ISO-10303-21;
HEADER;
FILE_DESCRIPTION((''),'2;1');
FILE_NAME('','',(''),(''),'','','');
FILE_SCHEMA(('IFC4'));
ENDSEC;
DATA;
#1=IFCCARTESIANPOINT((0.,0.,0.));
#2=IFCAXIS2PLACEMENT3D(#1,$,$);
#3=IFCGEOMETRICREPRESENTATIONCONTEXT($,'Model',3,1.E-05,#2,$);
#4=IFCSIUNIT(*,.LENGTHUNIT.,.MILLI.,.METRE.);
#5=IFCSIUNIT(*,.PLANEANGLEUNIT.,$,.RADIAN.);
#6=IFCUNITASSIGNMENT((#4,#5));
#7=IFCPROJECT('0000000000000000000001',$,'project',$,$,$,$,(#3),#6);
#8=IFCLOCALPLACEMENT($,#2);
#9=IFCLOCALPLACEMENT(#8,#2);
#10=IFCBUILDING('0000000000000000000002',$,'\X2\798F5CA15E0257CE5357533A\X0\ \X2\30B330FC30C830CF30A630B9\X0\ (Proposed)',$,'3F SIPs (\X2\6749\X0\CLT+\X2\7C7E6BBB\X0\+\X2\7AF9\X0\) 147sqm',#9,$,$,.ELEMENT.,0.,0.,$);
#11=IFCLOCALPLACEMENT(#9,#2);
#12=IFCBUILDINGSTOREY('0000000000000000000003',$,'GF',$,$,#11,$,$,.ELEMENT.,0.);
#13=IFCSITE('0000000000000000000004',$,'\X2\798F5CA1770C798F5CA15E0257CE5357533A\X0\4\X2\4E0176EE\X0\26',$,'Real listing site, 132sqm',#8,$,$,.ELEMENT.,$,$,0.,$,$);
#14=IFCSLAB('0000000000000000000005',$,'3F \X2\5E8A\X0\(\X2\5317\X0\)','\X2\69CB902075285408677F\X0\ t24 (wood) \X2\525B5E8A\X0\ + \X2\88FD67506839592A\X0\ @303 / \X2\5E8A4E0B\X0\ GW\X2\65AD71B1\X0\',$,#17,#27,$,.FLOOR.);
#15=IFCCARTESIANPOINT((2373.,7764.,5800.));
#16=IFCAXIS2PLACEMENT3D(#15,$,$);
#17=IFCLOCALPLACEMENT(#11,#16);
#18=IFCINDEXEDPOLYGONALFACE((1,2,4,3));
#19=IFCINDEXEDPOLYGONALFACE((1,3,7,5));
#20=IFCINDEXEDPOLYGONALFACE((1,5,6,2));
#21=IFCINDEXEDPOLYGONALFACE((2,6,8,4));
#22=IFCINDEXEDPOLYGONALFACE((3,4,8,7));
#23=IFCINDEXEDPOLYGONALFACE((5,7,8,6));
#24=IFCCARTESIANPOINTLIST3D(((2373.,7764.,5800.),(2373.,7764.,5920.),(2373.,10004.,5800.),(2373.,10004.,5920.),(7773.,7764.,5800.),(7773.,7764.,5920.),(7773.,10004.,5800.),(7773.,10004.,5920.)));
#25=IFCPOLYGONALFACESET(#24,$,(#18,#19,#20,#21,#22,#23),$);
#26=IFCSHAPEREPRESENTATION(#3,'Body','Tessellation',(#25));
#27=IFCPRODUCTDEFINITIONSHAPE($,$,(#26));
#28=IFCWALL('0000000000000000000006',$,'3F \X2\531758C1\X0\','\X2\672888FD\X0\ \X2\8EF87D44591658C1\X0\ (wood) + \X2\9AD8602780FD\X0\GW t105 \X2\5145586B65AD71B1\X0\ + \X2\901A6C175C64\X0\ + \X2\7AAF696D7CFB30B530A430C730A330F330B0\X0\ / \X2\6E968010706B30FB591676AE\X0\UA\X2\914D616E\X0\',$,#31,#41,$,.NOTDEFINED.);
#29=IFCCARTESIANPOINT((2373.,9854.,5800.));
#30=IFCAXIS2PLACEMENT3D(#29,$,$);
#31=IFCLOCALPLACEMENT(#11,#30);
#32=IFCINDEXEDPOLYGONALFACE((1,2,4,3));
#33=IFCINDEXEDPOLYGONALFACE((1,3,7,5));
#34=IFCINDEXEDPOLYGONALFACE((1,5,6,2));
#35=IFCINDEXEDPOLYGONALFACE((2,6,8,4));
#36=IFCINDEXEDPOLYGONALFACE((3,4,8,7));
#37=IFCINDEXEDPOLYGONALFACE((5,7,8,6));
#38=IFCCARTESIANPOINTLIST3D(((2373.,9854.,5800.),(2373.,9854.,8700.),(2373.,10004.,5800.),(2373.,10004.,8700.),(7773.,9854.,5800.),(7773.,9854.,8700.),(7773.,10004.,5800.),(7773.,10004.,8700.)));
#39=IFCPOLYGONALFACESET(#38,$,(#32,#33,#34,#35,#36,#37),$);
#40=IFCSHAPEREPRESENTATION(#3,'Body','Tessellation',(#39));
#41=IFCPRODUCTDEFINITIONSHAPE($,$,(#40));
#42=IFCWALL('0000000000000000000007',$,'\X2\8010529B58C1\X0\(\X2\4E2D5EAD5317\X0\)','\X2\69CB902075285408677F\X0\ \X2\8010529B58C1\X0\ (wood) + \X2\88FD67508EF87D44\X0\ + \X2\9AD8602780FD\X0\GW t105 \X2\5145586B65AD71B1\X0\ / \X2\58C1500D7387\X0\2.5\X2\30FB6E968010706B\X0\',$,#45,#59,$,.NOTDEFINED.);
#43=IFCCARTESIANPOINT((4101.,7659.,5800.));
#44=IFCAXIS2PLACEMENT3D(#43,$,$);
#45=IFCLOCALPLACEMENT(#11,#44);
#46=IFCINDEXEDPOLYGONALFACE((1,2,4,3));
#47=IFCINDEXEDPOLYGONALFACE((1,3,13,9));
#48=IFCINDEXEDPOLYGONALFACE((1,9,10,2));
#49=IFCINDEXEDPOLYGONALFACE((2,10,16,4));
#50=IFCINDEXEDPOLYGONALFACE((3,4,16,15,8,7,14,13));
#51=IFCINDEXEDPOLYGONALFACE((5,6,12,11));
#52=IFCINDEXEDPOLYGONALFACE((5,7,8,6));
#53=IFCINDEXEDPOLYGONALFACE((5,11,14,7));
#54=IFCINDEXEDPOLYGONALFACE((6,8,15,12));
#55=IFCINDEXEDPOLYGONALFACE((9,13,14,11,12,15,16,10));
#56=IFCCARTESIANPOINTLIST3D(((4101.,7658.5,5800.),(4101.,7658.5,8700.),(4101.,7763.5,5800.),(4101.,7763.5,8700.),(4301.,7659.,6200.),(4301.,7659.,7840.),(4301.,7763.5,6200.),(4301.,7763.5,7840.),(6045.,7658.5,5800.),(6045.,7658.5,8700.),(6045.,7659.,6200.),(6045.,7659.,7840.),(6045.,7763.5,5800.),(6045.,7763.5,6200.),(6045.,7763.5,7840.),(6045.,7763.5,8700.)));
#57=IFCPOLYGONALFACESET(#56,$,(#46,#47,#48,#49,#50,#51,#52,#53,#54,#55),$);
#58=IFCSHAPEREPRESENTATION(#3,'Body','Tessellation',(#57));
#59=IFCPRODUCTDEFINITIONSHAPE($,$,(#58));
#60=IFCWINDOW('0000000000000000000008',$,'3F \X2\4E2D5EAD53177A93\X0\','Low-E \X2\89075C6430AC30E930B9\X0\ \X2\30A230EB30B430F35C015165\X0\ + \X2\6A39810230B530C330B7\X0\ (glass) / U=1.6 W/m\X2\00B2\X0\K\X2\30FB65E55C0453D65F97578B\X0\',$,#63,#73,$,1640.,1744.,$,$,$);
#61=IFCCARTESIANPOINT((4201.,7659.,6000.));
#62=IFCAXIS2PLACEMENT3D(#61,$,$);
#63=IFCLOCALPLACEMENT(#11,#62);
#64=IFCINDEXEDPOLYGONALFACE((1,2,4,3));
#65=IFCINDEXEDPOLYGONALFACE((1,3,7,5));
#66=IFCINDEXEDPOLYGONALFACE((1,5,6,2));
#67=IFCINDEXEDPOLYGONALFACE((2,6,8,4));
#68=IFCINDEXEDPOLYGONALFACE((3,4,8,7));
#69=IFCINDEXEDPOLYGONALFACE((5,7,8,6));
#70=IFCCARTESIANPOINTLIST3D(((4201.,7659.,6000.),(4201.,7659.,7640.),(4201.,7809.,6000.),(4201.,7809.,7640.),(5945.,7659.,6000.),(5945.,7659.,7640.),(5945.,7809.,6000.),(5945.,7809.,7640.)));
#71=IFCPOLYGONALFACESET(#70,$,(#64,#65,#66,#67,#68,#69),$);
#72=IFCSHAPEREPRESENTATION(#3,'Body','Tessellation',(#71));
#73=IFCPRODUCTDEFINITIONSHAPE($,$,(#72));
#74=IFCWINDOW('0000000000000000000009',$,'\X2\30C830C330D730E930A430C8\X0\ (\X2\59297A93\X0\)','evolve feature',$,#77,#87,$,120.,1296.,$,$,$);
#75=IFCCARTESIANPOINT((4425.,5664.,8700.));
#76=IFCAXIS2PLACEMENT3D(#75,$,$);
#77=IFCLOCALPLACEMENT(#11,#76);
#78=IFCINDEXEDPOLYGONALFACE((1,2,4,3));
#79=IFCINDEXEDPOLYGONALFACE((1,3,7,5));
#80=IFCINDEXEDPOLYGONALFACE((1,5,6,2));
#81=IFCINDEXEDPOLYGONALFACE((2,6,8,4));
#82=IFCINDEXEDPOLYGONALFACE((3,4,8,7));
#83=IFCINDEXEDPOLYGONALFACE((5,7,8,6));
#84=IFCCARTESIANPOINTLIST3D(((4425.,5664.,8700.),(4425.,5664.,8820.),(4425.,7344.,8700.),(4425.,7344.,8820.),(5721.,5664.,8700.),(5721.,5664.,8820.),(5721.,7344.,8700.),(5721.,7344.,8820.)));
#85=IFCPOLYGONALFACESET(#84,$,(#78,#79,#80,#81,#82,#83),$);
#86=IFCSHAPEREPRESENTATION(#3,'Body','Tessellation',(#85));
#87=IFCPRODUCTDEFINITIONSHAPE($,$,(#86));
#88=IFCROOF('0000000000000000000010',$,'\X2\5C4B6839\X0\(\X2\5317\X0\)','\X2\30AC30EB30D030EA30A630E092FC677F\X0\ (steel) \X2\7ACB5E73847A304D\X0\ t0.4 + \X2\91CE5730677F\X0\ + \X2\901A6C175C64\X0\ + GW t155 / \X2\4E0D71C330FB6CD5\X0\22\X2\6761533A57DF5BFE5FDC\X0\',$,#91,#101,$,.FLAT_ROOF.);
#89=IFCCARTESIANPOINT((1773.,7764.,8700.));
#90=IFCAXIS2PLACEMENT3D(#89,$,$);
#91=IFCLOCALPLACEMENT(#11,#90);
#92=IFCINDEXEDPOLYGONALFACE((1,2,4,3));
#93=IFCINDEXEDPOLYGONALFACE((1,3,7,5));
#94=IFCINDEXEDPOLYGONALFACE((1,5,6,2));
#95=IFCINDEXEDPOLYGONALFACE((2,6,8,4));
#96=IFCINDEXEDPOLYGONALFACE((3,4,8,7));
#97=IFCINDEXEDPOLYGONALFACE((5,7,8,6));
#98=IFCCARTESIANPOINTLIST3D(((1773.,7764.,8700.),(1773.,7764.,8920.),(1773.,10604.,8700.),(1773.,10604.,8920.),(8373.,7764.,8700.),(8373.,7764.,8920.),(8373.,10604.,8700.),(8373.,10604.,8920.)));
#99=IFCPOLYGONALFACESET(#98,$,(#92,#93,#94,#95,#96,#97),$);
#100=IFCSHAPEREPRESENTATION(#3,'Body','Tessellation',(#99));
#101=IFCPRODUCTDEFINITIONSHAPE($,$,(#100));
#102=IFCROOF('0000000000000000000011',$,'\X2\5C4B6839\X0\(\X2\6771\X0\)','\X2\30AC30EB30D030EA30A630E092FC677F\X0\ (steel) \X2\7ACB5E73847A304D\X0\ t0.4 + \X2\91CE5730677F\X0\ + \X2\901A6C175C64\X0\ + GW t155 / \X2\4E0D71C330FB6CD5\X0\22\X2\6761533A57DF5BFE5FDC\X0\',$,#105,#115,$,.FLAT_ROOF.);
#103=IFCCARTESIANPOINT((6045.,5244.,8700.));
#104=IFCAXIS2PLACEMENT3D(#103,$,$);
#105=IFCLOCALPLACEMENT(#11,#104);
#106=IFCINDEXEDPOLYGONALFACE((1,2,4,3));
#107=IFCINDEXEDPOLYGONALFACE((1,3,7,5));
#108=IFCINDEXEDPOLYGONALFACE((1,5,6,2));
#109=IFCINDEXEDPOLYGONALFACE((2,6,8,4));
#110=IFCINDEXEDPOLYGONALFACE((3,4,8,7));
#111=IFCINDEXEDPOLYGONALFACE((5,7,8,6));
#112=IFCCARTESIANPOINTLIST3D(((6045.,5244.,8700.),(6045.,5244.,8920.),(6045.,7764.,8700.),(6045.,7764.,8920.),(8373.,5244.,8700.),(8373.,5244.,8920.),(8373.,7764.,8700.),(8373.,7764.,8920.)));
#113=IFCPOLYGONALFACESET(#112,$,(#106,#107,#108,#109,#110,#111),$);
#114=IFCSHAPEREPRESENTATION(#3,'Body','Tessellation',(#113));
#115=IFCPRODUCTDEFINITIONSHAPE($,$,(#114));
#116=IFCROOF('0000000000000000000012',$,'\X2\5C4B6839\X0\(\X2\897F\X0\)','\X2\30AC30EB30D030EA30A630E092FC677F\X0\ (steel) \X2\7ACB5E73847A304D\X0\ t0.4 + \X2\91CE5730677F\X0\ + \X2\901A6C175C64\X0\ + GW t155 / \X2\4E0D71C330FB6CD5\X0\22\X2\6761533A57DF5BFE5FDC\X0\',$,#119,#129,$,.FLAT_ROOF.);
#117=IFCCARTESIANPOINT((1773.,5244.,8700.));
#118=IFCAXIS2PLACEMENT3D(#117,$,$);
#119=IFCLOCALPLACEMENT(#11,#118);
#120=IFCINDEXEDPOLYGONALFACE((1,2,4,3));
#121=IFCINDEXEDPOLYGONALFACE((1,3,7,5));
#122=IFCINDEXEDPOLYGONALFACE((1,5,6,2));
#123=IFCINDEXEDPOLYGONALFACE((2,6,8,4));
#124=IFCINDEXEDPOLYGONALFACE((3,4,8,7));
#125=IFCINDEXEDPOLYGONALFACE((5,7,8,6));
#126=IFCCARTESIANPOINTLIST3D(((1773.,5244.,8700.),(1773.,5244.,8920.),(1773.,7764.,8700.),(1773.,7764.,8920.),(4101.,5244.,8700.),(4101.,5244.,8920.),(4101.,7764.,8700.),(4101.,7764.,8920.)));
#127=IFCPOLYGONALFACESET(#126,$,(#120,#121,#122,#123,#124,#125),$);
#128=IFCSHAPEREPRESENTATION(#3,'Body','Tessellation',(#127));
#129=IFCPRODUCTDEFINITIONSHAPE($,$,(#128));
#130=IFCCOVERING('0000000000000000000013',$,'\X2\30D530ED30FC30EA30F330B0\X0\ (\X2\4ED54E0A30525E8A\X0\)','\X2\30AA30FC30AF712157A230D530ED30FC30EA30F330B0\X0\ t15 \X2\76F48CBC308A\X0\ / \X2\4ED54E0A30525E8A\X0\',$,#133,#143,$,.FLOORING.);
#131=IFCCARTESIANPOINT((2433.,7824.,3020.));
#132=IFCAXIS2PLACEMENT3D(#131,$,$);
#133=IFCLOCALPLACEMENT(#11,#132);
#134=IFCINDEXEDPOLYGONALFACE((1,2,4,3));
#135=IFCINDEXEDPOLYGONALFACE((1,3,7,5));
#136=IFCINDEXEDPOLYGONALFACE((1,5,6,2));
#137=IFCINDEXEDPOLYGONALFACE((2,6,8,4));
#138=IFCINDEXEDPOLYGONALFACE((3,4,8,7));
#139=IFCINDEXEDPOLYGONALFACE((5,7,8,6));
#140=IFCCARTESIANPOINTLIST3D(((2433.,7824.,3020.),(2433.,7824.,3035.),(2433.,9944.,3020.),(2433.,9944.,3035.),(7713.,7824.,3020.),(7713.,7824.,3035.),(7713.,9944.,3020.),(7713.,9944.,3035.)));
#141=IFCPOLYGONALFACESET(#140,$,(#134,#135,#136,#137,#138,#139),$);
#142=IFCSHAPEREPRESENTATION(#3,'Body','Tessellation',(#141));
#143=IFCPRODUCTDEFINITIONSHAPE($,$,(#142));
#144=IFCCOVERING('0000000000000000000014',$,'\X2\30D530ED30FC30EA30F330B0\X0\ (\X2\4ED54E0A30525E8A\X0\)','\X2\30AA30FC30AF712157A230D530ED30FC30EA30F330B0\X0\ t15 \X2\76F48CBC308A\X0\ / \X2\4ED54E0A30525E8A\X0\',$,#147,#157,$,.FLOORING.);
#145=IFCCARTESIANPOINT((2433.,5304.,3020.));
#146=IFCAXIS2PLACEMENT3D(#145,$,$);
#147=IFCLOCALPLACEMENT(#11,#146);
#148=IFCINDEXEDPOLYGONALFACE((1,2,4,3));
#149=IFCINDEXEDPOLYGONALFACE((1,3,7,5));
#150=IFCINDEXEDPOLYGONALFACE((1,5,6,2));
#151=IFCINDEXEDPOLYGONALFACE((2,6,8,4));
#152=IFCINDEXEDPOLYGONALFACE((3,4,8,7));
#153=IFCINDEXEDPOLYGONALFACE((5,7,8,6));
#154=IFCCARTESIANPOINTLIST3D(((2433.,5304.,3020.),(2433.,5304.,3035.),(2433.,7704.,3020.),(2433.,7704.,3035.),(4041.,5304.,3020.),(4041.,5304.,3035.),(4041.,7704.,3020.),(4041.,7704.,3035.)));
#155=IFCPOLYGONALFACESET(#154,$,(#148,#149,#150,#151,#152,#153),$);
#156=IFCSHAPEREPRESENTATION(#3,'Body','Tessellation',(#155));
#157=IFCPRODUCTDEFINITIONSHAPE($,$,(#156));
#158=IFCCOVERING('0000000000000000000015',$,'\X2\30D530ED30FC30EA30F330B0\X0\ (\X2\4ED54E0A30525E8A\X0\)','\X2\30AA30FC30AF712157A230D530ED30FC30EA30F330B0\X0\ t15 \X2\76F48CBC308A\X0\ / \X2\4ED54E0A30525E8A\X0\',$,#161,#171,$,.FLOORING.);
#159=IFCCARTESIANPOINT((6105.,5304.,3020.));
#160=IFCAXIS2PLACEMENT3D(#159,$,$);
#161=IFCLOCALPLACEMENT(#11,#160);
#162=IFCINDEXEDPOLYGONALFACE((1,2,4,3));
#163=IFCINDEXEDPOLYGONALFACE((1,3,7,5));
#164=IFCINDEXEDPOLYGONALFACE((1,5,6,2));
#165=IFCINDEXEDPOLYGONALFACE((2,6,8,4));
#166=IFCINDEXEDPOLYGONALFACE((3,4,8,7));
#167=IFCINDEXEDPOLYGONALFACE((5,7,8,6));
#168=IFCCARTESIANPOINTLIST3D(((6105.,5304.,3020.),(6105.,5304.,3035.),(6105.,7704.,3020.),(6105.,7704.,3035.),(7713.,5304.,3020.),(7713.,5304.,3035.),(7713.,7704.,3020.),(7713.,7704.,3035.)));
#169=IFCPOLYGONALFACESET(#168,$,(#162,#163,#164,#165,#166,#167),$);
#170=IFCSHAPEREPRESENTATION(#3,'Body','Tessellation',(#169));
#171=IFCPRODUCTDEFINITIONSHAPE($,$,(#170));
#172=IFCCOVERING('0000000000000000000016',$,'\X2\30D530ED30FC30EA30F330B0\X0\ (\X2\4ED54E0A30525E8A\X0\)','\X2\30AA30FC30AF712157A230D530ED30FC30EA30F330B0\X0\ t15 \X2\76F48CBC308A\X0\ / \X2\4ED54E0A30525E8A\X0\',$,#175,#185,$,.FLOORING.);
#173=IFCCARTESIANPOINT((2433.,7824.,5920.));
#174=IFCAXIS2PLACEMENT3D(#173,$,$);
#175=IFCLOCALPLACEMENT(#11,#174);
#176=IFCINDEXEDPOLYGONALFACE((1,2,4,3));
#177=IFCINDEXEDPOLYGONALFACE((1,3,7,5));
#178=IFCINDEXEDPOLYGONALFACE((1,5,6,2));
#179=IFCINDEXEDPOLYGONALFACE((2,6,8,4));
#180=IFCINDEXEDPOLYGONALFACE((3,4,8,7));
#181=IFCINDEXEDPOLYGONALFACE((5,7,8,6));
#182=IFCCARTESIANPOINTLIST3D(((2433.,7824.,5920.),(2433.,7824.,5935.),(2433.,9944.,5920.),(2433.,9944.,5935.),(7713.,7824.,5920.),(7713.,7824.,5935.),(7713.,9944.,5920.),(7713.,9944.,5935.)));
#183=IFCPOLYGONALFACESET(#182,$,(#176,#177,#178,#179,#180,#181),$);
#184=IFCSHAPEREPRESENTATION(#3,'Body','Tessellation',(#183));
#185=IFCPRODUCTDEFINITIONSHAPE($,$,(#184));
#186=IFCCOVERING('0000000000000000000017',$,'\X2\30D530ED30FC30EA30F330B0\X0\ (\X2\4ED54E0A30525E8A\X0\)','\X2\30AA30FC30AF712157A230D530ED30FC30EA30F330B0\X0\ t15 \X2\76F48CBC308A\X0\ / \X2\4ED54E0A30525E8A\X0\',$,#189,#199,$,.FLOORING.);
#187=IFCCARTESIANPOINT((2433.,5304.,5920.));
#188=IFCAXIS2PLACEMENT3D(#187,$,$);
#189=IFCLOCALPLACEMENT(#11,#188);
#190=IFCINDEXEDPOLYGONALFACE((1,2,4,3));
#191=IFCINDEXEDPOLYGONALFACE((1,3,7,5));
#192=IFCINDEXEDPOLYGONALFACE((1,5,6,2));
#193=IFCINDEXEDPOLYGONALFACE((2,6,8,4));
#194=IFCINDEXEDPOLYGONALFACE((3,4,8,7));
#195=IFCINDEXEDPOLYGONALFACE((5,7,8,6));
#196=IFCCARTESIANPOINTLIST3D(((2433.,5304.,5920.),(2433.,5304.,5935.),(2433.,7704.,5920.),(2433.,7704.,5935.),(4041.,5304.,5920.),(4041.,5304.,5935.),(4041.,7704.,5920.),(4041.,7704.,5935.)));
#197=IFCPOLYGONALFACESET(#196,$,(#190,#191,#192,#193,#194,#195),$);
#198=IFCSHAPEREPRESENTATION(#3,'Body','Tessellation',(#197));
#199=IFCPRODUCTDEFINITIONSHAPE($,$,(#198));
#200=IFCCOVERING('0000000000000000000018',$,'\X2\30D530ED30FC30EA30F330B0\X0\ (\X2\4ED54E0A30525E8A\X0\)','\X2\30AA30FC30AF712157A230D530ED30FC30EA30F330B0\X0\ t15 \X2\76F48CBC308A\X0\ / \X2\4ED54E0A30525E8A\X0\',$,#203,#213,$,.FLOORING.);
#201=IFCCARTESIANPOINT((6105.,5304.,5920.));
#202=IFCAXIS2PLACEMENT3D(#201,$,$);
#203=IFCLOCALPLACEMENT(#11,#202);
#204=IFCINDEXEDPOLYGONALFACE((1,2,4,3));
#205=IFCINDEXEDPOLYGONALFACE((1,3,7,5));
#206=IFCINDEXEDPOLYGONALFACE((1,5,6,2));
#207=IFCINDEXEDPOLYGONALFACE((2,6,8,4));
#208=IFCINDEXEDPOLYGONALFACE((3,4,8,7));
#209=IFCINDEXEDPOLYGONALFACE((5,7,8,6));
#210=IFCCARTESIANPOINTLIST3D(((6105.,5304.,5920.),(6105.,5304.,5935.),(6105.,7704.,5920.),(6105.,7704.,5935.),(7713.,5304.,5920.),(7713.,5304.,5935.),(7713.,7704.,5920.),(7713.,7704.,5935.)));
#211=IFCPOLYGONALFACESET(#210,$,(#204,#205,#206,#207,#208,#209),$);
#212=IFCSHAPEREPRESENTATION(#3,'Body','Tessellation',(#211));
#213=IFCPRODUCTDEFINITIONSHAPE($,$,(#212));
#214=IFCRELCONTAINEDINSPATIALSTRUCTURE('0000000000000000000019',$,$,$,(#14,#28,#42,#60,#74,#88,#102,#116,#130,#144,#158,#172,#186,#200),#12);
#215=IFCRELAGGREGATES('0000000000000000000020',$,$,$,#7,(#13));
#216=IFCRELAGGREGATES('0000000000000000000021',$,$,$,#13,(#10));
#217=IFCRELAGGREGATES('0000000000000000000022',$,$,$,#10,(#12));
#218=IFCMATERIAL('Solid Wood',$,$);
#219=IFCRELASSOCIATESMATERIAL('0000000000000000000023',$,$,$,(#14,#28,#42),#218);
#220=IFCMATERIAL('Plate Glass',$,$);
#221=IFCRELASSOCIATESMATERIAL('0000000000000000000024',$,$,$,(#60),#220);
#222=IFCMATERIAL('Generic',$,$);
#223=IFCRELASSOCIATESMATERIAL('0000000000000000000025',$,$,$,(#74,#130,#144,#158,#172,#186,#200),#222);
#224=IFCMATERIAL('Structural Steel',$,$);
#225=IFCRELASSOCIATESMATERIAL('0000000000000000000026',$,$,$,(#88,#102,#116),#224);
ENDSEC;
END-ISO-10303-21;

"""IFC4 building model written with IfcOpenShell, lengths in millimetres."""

from ifc_helpers import new_model, si_unit, frame, frame_2d, origin, place, context, project, spatial, rectangle, extrude, material, element, fill, save


model = new_model("IFC4")

# Units and contexts
model_context = context("Model", 3, precision=1e-05, world=origin())
ifc_project = project(units=[si_unit("LENGTHUNIT", "METRE", prefix="MILLI"), si_unit("PLANEANGLEUNIT", "RADIAN")], contexts=[model_context])

# Site, building, storey
site_placement = place(None, origin())
site = spatial("IfcSite", under=ifc_project, at=site_placement, Name="福岡県福岡市城南区4丁目26", ObjectType="Real listing site, 132sqm", CompositionType="ELEMENT", RefElevation=0.0)
building_placement = place(site_placement, origin())
building = spatial("IfcBuilding", under=site, at=building_placement, Name="福岡市城南区 コートハウス (Proposed)", ObjectType="3F SIPs (杉CLT+籾殻+竹) 147sqm", CompositionType="ELEMENT", ElevationOfRefHeight=0.0, ElevationOfTerrain=0.0)
storey_placement = place(building_placement, origin())
storey = spatial("IfcBuildingStorey", under=building, at=storey_placement, Name="GF", CompositionType="ELEMENT", Elevation=0.0)

# Slab
ifc_material_1 = material(Name="Solid Wood")
slab_placement = place(storey_placement, frame((2373.0, 7764.0, 5800.0)))
element("IfcSlab", 1, at=slab_placement, inside=storey, material=ifc_material_1, Name="3F 床(北)", Description="構造用合板 t24 (wood) 剛床 + 製材根太 @303 / 床下 GW断熱", PredefinedType="FLOOR", context=model_context, shape_type="SweptSolid", body=[
    extrude(rectangle(XDim=5400.0, YDim=2240.0, at=frame_2d((2700.0, 1120.0))), frame((2373.0, 7764.0, 5800.0)), (0.0, 0.0, 1.0), 120.0),
])

# Wall
wall_1_placement = place(storey_placement, frame((2373.0, 9854.0, 5800.0)))
element("IfcWall", 2, at=wall_1_placement, inside=storey, material=ifc_material_1, Name="3F 北壁", Description="木製 軸組外壁 (wood) + 高性能GW t105 充填断熱 + 通気層 + 窯業系サイディング / 準耐火・外皮UA配慮", PredefinedType="NOTDEFINED", context=model_context, shape_type="SweptSolid", body=[
    extrude(rectangle(XDim=5400.0, YDim=150.0, at=frame_2d((2700.0, 75.0))), frame((2373.0, 9854.0, 5800.0)), (0.0, 0.0, 1.0), 2900.0),
])

# Wall, opening, window
wall_2_placement = place(storey_placement, frame((4101.0, 7659.0, 5800.0)))
wall_2 = element("IfcWall", 3, at=wall_2_placement, inside=storey, material=ifc_material_1, Name="耐力壁(中庭北)", Description="構造用合板 耐力壁 (wood) + 製材軸組 + 高性能GW t105 充填断熱 / 壁倍率2.5・準耐火", PredefinedType="NOTDEFINED", context=model_context, shape_type="SweptSolid", body=[
    extrude(rectangle(XDim=1944.0, YDim=105.0, at=frame_2d((972.0, 52.0))), frame((4101.0, 7659.0, 5800.0)), (0.0, 0.0, 1.0), 2900.0),
])
opening_placement = place(storey_placement, frame((4201.0, 7659.0, 6000.0)))
opening = element("IfcOpeningElement", 4, at=opening_placement, cuts=wall_2, PredefinedType="NOTDEFINED", context=model_context, shape_type="SweptSolid", body=[
    extrude(rectangle(XDim=1744.0, YDim=150.0, at=frame_2d((872.0, 75.0))), frame((4201.0, 7659.0, 6000.0)), (0.0, 0.0, 1.0), 1640.0),
])
ifc_material_2 = material(Name="Plate Glass")
window_1_placement = place(storey_placement, frame((4201.0, 7659.0, 6000.0)))
window_1 = element("IfcWindow", 5, at=window_1_placement, inside=storey, material=ifc_material_2, Name="3F 中庭北窓", Description="Low-E 複層ガラス アルゴン封入 + 樹脂サッシ (glass) / U=1.6 W/m²K・日射取得型", OverallHeight=1640.0, OverallWidth=1744.0, context=model_context, shape_type="SweptSolid", body=[
    extrude(rectangle(XDim=1744.0, YDim=150.0, at=frame_2d((872.0, 75.0))), frame((4201.0, 7659.0, 6000.0)), (0.0, 0.0, 1.0), 1640.0),
])
fill(opening, window_1)

# Window
ifc_material_3 = material(Name="Generic")
window_2_placement = place(storey_placement, frame((4425.0, 5664.0, 8700.0)))
element("IfcWindow", 6, at=window_2_placement, inside=storey, material=ifc_material_3, Name="トップライト (天窓)", Description="evolve feature", OverallHeight=120.0, OverallWidth=1296.0, context=model_context, shape_type="SweptSolid", body=[
    extrude(rectangle(XDim=1296.0, YDim=1680.0, at=frame_2d((648.0, 840.0))), frame((4425.0, 5664.0, 8700.0)), (0.0, 0.0, 1.0), 120.0),
])

# Roofs
ifc_material_4 = material(Name="Structural Steel")
roof_1_placement = place(storey_placement, frame((1773.0, 7764.0, 8700.0)))
element("IfcRoof", 7, at=roof_1_placement, inside=storey, material=ifc_material_4, Name="屋根(北)", Description="ガルバリウム鋼板 (steel) 立平葺き t0.4 + 野地板 + 通気層 + GW t155 / 不燃・法22条区域対応", PredefinedType="FLAT_ROOF", context=model_context, shape_type="SweptSolid", body=[
    extrude(rectangle(XDim=6600.0, YDim=2840.0, at=frame_2d((3300.0, 1420.0))), frame((1773.0, 7764.0, 8700.0)), (0.0, 0.0, 1.0), 220.0),
])
roof_2_placement = place(storey_placement, frame((6045.0, 5244.0, 8700.0)))
element("IfcRoof", 8, at=roof_2_placement, inside=storey, material=ifc_material_4, Name="屋根(東)", Description="ガルバリウム鋼板 (steel) 立平葺き t0.4 + 野地板 + 通気層 + GW t155 / 不燃・法22条区域対応", PredefinedType="FLAT_ROOF", context=model_context, shape_type="SweptSolid", body=[
    extrude(rectangle(XDim=2328.0, YDim=2520.0, at=frame_2d((1164.0, 1260.0))), frame((6045.0, 5244.0, 8700.0)), (0.0, 0.0, 1.0), 220.0),
])
roof_3_placement = place(storey_placement, frame((1773.0, 5244.0, 8700.0)))
element("IfcRoof", 9, at=roof_3_placement, inside=storey, material=ifc_material_4, Name="屋根(西)", Description="ガルバリウム鋼板 (steel) 立平葺き t0.4 + 野地板 + 通気層 + GW t155 / 不燃・法22条区域対応", PredefinedType="FLAT_ROOF", context=model_context, shape_type="SweptSolid", body=[
    extrude(rectangle(XDim=2328.0, YDim=2520.0, at=frame_2d((1164.0, 1260.0))), frame((1773.0, 5244.0, 8700.0)), (0.0, 0.0, 1.0), 220.0),
])

# Coverings
covering_1_placement = place(storey_placement, frame((2433.0, 7824.0, 3020.0)))
element("IfcCovering", 10, at=covering_1_placement, inside=storey, material=ifc_material_3, Name="フローリング (仕上げ床)", Description="オーク無垢フローリング t15 直貼り / 仕上げ床", PredefinedType="FLOORING", context=model_context, shape_type="SweptSolid", body=[
    extrude(rectangle(XDim=5280.0, YDim=2120.0, at=frame_2d((2640.0, 1060.0))), frame((2433.0, 7824.0, 3020.0)), (0.0, 0.0, 1.0), 15.0),
])
covering_2_placement = place(storey_placement, frame((2433.0, 5304.0, 3020.0)))
element("IfcCovering", 11, at=covering_2_placement, inside=storey, material=ifc_material_3, Name="フローリング (仕上げ床)", Description="オーク無垢フローリング t15 直貼り / 仕上げ床", PredefinedType="FLOORING", context=model_context, shape_type="SweptSolid", body=[
    extrude(rectangle(XDim=1608.0, YDim=2400.0, at=frame_2d((804.0, 1200.0))), frame((2433.0, 5304.0, 3020.0)), (0.0, 0.0, 1.0), 15.0),
])
covering_3_placement = place(storey_placement, frame((6105.0, 5304.0, 3020.0)))
element("IfcCovering", 12, at=covering_3_placement, inside=storey, material=ifc_material_3, Name="フローリング (仕上げ床)", Description="オーク無垢フローリング t15 直貼り / 仕上げ床", PredefinedType="FLOORING", context=model_context, shape_type="SweptSolid", body=[
    extrude(rectangle(XDim=1608.0, YDim=2400.0, at=frame_2d((804.0, 1200.0))), frame((6105.0, 5304.0, 3020.0)), (0.0, 0.0, 1.0), 15.0),
])
covering_4_placement = place(storey_placement, frame((2433.0, 7824.0, 5920.0)))
element("IfcCovering", 13, at=covering_4_placement, inside=storey, material=ifc_material_3, Name="フローリング (仕上げ床)", Description="オーク無垢フローリング t15 直貼り / 仕上げ床", PredefinedType="FLOORING", context=model_context, shape_type="SweptSolid", body=[
    extrude(rectangle(XDim=5280.0, YDim=2120.0, at=frame_2d((2640.0, 1060.0))), frame((2433.0, 7824.0, 5920.0)), (0.0, 0.0, 1.0), 15.0),
])
covering_5_placement = place(storey_placement, frame((2433.0, 5304.0, 5920.0)))
element("IfcCovering", 14, at=covering_5_placement, inside=storey, material=ifc_material_3, Name="フローリング (仕上げ床)", Description="オーク無垢フローリング t15 直貼り / 仕上げ床", PredefinedType="FLOORING", context=model_context, shape_type="SweptSolid", body=[
    extrude(rectangle(XDim=1608.0, YDim=2400.0, at=frame_2d((804.0, 1200.0))), frame((2433.0, 5304.0, 5920.0)), (0.0, 0.0, 1.0), 15.0),
])
covering_6_placement = place(storey_placement, frame((6105.0, 5304.0, 5920.0)))
element("IfcCovering", 15, at=covering_6_placement, inside=storey, material=ifc_material_3, Name="フローリング (仕上げ床)", Description="オーク無垢フローリング t15 直貼り / 仕上げ床", PredefinedType="FLOORING", context=model_context, shape_type="SweptSolid", body=[
    extrude(rectangle(XDim=1608.0, YDim=2400.0, at=frame_2d((804.0, 1200.0))), frame((6105.0, 5304.0, 5920.0)), (0.0, 0.0, 1.0), 15.0),
])

save(model, "model.ifc")
